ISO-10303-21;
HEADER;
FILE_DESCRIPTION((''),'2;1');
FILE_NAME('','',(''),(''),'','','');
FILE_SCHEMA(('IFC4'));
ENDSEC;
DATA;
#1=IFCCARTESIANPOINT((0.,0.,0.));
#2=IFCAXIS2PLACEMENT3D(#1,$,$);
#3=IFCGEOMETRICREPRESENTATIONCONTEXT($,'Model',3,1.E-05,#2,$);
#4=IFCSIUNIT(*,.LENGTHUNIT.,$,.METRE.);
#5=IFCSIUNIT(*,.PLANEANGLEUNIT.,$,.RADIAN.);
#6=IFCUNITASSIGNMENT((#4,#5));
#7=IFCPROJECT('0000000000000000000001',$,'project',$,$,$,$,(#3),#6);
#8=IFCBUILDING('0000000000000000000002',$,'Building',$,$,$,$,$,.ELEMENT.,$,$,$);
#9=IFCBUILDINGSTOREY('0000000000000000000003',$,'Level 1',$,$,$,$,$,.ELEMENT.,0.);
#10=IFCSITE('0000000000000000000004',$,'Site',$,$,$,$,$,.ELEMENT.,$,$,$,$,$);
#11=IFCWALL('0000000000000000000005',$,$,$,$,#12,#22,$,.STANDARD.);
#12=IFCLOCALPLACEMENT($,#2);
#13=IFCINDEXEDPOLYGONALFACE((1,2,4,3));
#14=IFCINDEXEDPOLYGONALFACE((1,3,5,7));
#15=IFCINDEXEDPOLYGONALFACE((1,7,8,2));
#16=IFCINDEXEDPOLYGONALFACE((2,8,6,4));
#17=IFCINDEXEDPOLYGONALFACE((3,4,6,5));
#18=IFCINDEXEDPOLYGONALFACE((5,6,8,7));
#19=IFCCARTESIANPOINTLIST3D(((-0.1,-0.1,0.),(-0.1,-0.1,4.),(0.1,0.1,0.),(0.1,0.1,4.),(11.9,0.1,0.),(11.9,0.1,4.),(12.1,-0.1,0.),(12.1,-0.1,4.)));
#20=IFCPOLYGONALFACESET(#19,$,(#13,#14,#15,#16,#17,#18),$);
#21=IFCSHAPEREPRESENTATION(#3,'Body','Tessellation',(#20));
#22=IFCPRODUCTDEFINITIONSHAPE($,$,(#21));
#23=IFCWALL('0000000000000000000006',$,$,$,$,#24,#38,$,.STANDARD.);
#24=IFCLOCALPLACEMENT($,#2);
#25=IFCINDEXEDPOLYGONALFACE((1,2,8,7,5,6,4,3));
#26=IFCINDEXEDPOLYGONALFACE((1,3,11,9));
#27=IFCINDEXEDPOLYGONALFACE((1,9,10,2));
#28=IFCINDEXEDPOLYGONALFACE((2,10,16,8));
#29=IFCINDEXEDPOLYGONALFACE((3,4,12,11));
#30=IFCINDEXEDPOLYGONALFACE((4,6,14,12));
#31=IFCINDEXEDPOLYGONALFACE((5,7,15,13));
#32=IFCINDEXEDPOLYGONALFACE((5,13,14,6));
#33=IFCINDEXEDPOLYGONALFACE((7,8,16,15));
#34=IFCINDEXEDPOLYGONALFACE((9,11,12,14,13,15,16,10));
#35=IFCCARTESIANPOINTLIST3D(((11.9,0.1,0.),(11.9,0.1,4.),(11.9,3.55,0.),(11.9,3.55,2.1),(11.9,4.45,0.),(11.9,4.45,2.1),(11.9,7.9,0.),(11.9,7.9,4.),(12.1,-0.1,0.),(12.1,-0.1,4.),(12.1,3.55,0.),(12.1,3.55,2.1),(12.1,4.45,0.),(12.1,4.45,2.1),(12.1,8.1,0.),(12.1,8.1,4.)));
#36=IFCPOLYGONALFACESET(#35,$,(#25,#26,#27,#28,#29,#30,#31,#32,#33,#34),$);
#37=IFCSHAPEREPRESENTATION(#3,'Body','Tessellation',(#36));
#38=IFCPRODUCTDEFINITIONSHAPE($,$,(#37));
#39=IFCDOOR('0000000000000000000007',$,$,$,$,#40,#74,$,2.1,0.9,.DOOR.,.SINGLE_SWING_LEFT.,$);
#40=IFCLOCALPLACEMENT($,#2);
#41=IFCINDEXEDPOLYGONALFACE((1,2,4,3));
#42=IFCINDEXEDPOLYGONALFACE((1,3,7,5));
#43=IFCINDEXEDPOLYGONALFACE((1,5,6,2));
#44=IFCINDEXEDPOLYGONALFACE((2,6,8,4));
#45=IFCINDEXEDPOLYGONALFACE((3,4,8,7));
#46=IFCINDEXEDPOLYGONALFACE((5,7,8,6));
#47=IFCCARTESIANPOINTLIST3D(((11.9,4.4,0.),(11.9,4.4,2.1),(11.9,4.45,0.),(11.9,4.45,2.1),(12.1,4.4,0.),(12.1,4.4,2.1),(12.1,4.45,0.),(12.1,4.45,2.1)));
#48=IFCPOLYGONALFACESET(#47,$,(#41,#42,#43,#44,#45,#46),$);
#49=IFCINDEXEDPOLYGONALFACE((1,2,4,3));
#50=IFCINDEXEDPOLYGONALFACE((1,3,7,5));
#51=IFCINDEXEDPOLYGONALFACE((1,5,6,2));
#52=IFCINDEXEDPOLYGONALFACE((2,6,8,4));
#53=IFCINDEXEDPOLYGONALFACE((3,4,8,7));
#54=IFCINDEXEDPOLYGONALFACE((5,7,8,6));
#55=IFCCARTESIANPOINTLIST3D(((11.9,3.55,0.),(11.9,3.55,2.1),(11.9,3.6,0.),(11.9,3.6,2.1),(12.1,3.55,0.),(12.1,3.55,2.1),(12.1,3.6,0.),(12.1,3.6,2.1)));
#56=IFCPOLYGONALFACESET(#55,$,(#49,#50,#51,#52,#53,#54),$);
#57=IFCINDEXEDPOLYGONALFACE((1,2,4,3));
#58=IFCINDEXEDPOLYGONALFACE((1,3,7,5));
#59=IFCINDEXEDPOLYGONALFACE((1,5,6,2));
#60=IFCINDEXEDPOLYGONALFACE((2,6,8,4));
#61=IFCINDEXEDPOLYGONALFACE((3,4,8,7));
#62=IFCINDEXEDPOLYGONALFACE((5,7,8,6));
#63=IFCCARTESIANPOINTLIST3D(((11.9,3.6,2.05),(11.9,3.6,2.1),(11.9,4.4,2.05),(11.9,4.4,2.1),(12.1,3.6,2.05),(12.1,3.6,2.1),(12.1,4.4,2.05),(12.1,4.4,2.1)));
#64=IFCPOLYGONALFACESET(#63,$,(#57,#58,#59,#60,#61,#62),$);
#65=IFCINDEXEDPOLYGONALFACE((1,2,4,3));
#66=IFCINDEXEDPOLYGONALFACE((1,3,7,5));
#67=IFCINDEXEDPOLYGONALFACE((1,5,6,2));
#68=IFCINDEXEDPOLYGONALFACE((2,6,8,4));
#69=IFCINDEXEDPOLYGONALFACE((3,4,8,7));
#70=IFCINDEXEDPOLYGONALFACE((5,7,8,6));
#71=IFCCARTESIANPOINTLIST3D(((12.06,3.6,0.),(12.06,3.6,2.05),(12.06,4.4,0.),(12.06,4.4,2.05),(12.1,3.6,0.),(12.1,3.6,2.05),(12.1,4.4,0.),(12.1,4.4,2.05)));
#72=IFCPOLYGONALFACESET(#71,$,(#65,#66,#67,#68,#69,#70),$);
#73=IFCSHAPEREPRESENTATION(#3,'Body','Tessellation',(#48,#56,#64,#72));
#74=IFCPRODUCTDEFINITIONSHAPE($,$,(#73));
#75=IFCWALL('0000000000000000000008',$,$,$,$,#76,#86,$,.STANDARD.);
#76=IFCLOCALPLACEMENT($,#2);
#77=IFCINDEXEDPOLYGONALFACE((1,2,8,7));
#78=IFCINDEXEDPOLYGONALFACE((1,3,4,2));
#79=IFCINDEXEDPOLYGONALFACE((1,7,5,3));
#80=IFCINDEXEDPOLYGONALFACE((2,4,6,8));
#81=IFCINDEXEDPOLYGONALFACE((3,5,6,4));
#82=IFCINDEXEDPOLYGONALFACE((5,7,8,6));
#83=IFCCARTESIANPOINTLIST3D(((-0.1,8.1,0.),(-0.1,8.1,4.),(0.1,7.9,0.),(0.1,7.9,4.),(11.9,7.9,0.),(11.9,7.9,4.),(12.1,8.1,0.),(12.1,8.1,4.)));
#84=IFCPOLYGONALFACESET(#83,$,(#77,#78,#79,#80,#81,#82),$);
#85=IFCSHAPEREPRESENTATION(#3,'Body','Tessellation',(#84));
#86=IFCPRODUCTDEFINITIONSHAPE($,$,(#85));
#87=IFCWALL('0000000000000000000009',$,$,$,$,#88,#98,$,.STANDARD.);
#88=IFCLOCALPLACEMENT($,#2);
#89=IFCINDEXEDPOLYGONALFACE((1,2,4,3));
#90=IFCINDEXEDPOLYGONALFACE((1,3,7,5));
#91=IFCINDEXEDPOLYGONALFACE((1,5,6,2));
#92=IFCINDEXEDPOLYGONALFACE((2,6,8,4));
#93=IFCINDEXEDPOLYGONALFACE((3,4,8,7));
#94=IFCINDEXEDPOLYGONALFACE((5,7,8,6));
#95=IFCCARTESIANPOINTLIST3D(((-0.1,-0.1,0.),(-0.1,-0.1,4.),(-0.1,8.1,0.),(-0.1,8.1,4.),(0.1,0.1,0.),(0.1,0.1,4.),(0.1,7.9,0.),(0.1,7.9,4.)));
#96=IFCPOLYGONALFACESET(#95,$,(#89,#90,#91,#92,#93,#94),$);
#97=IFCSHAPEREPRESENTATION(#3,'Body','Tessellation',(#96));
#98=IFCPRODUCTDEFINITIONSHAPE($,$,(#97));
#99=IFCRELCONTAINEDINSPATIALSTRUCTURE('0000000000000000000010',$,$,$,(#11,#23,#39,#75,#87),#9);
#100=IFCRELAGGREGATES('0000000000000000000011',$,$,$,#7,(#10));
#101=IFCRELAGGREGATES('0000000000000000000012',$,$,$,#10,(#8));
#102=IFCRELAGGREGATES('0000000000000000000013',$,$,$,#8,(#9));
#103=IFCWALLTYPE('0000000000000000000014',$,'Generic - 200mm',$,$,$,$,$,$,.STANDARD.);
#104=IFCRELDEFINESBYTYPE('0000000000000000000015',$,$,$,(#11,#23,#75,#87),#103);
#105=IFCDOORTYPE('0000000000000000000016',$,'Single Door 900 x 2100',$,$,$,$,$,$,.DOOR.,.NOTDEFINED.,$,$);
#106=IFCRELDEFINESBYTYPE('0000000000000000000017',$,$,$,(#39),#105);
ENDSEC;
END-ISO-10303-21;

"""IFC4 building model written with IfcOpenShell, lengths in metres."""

from ifc_helpers import new_model, si_unit, frame, frame_2d, origin, origin_with_axes, origin_2d, place, context, project, spatial, polyline, rectangle, outline, extrude, type_object, element, fill, save


model = new_model("IFC4")

# Units and contexts
model_context = context("Model", 3, precision=1e-05, world=origin())
ifc_project = project(units=[si_unit("LENGTHUNIT", "METRE"), si_unit("PLANEANGLEUNIT", "RADIAN")], contexts=[model_context])

# Site, building, storey
site = spatial("IfcSite", under=ifc_project, Name="Site", CompositionType="ELEMENT")
building = spatial("IfcBuilding", under=site, Name="Building", CompositionType="ELEMENT")
storey = spatial("IfcBuildingStorey", under=building, Name="Level 1", CompositionType="ELEMENT", Elevation=0.0)

# Wall
wall_type = type_object("IfcWallType", Name="Generic - 200mm", PredefinedType="STANDARD")
wall_1_placement = place(None, frame((12.0, 0.0, 0.0), z_axis=(0.0, 0.0, 1.0), x_axis=(-1.0, 0.0, 0.0)))
element("IfcWall", 1, at=wall_1_placement, inside=storey, type_object=wall_type, PredefinedType="STANDARD", context=model_context, shape_type="SweptSolid", body=[
    extrude(outline(polyline([(0.1, -0.1), (11.9, -0.1), (12.1, 0.1), (-0.1, 0.1), (0.1, -0.1)])), origin(), (0.0, 0.0, 1.0), 4.0),
])

# Wall, opening, door
wall_2_placement = place(None, frame((12.0, 8.0, 0.0), z_axis=(0.0, 0.0, 1.0), x_axis=(0.0, -1.0, 0.0)))
wall_2 = element("IfcWall", 2, at=wall_2_placement, inside=storey, type_object=wall_type, PredefinedType="STANDARD", context=model_context, shape_type="SweptSolid", body=[
    extrude(outline(polyline([(0.1, -0.1), (7.9, -0.1), (8.1, 0.1), (-0.1, 0.1), (0.1, -0.1)])), origin(), (0.0, 0.0, 1.0), 4.0),
])
opening_placement = place(wall_2_placement, frame((4.0, 0.0, 0.0), z_axis=(0.0, 0.0, 1.0), x_axis=(1.0, 0.0, 0.0)))
opening = element("IfcOpeningElement", 3, at=opening_placement, cuts=wall_2, PredefinedType="OPENING", context=model_context, shape_type="SweptSolid", body=[
    extrude(rectangle(XDim=0.9, YDim=0.202, at=origin_2d()), origin(), (0.0, 0.0, 1.0), 2.1),
])
door_type = type_object("IfcDoorType", Name="Single Door 900 x 2100", OperationType="NOTDEFINED", PredefinedType="DOOR")
door_placement = place(opening_placement, origin_with_axes())
door = element("IfcDoor", 4, at=door_placement, inside=storey, type_object=door_type, OperationType="SINGLE_SWING_LEFT", OverallHeight=2.1, OverallWidth=0.9, PredefinedType="DOOR", context=model_context, shape_type="SweptSolid", body=[
    extrude(rectangle(XDim=0.05, YDim=0.2, at=frame_2d((-0.425, 0.0))), origin(), (0.0, 0.0, 1.0), 2.1),
    extrude(rectangle(XDim=0.05, YDim=0.2, at=frame_2d((0.425, 0.0))), origin(), (0.0, 0.0, 1.0), 2.1),
    extrude(rectangle(XDim=0.8, YDim=0.2, at=origin_2d()), frame((0.0, 0.0, 2.05)), (0.0, 0.0, 1.0), 0.05),
    extrude(rectangle(XDim=0.8, YDim=0.04, at=frame_2d((0.0, 0.08))), origin(), (0.0, 0.0, 1.0), 2.05),
])
fill(opening, door)

# Walls
wall_3_placement = place(None, frame((0.0, 8.0, 0.0), z_axis=(0.0, 0.0, 1.0), x_axis=(1.0, 0.0, 0.0)))
element("IfcWall", 5, at=wall_3_placement, inside=storey, type_object=wall_type, PredefinedType="STANDARD", context=model_context, shape_type="SweptSolid", body=[
    extrude(outline(polyline([(0.1, -0.1), (11.9, -0.1), (12.1, 0.1), (-0.1, 0.1), (0.1, -0.1)])), origin(), (0.0, 0.0, 1.0), 4.0),
])
wall_4_placement = place(None, frame((0.0, 0.0, 0.0), z_axis=(0.0, 0.0, 1.0), x_axis=(0.0, 1.0, 0.0)))
element("IfcWall", 6, at=wall_4_placement, inside=storey, type_object=wall_type, PredefinedType="STANDARD", context=model_context, shape_type="SweptSolid", body=[
    extrude(outline(polyline([(0.1, -0.1), (7.9, -0.1), (8.1, 0.1), (-0.1, 0.1), (0.1, -0.1)])), origin(), (0.0, 0.0, 1.0), 4.0),
])

save(model, "model.ifc")
